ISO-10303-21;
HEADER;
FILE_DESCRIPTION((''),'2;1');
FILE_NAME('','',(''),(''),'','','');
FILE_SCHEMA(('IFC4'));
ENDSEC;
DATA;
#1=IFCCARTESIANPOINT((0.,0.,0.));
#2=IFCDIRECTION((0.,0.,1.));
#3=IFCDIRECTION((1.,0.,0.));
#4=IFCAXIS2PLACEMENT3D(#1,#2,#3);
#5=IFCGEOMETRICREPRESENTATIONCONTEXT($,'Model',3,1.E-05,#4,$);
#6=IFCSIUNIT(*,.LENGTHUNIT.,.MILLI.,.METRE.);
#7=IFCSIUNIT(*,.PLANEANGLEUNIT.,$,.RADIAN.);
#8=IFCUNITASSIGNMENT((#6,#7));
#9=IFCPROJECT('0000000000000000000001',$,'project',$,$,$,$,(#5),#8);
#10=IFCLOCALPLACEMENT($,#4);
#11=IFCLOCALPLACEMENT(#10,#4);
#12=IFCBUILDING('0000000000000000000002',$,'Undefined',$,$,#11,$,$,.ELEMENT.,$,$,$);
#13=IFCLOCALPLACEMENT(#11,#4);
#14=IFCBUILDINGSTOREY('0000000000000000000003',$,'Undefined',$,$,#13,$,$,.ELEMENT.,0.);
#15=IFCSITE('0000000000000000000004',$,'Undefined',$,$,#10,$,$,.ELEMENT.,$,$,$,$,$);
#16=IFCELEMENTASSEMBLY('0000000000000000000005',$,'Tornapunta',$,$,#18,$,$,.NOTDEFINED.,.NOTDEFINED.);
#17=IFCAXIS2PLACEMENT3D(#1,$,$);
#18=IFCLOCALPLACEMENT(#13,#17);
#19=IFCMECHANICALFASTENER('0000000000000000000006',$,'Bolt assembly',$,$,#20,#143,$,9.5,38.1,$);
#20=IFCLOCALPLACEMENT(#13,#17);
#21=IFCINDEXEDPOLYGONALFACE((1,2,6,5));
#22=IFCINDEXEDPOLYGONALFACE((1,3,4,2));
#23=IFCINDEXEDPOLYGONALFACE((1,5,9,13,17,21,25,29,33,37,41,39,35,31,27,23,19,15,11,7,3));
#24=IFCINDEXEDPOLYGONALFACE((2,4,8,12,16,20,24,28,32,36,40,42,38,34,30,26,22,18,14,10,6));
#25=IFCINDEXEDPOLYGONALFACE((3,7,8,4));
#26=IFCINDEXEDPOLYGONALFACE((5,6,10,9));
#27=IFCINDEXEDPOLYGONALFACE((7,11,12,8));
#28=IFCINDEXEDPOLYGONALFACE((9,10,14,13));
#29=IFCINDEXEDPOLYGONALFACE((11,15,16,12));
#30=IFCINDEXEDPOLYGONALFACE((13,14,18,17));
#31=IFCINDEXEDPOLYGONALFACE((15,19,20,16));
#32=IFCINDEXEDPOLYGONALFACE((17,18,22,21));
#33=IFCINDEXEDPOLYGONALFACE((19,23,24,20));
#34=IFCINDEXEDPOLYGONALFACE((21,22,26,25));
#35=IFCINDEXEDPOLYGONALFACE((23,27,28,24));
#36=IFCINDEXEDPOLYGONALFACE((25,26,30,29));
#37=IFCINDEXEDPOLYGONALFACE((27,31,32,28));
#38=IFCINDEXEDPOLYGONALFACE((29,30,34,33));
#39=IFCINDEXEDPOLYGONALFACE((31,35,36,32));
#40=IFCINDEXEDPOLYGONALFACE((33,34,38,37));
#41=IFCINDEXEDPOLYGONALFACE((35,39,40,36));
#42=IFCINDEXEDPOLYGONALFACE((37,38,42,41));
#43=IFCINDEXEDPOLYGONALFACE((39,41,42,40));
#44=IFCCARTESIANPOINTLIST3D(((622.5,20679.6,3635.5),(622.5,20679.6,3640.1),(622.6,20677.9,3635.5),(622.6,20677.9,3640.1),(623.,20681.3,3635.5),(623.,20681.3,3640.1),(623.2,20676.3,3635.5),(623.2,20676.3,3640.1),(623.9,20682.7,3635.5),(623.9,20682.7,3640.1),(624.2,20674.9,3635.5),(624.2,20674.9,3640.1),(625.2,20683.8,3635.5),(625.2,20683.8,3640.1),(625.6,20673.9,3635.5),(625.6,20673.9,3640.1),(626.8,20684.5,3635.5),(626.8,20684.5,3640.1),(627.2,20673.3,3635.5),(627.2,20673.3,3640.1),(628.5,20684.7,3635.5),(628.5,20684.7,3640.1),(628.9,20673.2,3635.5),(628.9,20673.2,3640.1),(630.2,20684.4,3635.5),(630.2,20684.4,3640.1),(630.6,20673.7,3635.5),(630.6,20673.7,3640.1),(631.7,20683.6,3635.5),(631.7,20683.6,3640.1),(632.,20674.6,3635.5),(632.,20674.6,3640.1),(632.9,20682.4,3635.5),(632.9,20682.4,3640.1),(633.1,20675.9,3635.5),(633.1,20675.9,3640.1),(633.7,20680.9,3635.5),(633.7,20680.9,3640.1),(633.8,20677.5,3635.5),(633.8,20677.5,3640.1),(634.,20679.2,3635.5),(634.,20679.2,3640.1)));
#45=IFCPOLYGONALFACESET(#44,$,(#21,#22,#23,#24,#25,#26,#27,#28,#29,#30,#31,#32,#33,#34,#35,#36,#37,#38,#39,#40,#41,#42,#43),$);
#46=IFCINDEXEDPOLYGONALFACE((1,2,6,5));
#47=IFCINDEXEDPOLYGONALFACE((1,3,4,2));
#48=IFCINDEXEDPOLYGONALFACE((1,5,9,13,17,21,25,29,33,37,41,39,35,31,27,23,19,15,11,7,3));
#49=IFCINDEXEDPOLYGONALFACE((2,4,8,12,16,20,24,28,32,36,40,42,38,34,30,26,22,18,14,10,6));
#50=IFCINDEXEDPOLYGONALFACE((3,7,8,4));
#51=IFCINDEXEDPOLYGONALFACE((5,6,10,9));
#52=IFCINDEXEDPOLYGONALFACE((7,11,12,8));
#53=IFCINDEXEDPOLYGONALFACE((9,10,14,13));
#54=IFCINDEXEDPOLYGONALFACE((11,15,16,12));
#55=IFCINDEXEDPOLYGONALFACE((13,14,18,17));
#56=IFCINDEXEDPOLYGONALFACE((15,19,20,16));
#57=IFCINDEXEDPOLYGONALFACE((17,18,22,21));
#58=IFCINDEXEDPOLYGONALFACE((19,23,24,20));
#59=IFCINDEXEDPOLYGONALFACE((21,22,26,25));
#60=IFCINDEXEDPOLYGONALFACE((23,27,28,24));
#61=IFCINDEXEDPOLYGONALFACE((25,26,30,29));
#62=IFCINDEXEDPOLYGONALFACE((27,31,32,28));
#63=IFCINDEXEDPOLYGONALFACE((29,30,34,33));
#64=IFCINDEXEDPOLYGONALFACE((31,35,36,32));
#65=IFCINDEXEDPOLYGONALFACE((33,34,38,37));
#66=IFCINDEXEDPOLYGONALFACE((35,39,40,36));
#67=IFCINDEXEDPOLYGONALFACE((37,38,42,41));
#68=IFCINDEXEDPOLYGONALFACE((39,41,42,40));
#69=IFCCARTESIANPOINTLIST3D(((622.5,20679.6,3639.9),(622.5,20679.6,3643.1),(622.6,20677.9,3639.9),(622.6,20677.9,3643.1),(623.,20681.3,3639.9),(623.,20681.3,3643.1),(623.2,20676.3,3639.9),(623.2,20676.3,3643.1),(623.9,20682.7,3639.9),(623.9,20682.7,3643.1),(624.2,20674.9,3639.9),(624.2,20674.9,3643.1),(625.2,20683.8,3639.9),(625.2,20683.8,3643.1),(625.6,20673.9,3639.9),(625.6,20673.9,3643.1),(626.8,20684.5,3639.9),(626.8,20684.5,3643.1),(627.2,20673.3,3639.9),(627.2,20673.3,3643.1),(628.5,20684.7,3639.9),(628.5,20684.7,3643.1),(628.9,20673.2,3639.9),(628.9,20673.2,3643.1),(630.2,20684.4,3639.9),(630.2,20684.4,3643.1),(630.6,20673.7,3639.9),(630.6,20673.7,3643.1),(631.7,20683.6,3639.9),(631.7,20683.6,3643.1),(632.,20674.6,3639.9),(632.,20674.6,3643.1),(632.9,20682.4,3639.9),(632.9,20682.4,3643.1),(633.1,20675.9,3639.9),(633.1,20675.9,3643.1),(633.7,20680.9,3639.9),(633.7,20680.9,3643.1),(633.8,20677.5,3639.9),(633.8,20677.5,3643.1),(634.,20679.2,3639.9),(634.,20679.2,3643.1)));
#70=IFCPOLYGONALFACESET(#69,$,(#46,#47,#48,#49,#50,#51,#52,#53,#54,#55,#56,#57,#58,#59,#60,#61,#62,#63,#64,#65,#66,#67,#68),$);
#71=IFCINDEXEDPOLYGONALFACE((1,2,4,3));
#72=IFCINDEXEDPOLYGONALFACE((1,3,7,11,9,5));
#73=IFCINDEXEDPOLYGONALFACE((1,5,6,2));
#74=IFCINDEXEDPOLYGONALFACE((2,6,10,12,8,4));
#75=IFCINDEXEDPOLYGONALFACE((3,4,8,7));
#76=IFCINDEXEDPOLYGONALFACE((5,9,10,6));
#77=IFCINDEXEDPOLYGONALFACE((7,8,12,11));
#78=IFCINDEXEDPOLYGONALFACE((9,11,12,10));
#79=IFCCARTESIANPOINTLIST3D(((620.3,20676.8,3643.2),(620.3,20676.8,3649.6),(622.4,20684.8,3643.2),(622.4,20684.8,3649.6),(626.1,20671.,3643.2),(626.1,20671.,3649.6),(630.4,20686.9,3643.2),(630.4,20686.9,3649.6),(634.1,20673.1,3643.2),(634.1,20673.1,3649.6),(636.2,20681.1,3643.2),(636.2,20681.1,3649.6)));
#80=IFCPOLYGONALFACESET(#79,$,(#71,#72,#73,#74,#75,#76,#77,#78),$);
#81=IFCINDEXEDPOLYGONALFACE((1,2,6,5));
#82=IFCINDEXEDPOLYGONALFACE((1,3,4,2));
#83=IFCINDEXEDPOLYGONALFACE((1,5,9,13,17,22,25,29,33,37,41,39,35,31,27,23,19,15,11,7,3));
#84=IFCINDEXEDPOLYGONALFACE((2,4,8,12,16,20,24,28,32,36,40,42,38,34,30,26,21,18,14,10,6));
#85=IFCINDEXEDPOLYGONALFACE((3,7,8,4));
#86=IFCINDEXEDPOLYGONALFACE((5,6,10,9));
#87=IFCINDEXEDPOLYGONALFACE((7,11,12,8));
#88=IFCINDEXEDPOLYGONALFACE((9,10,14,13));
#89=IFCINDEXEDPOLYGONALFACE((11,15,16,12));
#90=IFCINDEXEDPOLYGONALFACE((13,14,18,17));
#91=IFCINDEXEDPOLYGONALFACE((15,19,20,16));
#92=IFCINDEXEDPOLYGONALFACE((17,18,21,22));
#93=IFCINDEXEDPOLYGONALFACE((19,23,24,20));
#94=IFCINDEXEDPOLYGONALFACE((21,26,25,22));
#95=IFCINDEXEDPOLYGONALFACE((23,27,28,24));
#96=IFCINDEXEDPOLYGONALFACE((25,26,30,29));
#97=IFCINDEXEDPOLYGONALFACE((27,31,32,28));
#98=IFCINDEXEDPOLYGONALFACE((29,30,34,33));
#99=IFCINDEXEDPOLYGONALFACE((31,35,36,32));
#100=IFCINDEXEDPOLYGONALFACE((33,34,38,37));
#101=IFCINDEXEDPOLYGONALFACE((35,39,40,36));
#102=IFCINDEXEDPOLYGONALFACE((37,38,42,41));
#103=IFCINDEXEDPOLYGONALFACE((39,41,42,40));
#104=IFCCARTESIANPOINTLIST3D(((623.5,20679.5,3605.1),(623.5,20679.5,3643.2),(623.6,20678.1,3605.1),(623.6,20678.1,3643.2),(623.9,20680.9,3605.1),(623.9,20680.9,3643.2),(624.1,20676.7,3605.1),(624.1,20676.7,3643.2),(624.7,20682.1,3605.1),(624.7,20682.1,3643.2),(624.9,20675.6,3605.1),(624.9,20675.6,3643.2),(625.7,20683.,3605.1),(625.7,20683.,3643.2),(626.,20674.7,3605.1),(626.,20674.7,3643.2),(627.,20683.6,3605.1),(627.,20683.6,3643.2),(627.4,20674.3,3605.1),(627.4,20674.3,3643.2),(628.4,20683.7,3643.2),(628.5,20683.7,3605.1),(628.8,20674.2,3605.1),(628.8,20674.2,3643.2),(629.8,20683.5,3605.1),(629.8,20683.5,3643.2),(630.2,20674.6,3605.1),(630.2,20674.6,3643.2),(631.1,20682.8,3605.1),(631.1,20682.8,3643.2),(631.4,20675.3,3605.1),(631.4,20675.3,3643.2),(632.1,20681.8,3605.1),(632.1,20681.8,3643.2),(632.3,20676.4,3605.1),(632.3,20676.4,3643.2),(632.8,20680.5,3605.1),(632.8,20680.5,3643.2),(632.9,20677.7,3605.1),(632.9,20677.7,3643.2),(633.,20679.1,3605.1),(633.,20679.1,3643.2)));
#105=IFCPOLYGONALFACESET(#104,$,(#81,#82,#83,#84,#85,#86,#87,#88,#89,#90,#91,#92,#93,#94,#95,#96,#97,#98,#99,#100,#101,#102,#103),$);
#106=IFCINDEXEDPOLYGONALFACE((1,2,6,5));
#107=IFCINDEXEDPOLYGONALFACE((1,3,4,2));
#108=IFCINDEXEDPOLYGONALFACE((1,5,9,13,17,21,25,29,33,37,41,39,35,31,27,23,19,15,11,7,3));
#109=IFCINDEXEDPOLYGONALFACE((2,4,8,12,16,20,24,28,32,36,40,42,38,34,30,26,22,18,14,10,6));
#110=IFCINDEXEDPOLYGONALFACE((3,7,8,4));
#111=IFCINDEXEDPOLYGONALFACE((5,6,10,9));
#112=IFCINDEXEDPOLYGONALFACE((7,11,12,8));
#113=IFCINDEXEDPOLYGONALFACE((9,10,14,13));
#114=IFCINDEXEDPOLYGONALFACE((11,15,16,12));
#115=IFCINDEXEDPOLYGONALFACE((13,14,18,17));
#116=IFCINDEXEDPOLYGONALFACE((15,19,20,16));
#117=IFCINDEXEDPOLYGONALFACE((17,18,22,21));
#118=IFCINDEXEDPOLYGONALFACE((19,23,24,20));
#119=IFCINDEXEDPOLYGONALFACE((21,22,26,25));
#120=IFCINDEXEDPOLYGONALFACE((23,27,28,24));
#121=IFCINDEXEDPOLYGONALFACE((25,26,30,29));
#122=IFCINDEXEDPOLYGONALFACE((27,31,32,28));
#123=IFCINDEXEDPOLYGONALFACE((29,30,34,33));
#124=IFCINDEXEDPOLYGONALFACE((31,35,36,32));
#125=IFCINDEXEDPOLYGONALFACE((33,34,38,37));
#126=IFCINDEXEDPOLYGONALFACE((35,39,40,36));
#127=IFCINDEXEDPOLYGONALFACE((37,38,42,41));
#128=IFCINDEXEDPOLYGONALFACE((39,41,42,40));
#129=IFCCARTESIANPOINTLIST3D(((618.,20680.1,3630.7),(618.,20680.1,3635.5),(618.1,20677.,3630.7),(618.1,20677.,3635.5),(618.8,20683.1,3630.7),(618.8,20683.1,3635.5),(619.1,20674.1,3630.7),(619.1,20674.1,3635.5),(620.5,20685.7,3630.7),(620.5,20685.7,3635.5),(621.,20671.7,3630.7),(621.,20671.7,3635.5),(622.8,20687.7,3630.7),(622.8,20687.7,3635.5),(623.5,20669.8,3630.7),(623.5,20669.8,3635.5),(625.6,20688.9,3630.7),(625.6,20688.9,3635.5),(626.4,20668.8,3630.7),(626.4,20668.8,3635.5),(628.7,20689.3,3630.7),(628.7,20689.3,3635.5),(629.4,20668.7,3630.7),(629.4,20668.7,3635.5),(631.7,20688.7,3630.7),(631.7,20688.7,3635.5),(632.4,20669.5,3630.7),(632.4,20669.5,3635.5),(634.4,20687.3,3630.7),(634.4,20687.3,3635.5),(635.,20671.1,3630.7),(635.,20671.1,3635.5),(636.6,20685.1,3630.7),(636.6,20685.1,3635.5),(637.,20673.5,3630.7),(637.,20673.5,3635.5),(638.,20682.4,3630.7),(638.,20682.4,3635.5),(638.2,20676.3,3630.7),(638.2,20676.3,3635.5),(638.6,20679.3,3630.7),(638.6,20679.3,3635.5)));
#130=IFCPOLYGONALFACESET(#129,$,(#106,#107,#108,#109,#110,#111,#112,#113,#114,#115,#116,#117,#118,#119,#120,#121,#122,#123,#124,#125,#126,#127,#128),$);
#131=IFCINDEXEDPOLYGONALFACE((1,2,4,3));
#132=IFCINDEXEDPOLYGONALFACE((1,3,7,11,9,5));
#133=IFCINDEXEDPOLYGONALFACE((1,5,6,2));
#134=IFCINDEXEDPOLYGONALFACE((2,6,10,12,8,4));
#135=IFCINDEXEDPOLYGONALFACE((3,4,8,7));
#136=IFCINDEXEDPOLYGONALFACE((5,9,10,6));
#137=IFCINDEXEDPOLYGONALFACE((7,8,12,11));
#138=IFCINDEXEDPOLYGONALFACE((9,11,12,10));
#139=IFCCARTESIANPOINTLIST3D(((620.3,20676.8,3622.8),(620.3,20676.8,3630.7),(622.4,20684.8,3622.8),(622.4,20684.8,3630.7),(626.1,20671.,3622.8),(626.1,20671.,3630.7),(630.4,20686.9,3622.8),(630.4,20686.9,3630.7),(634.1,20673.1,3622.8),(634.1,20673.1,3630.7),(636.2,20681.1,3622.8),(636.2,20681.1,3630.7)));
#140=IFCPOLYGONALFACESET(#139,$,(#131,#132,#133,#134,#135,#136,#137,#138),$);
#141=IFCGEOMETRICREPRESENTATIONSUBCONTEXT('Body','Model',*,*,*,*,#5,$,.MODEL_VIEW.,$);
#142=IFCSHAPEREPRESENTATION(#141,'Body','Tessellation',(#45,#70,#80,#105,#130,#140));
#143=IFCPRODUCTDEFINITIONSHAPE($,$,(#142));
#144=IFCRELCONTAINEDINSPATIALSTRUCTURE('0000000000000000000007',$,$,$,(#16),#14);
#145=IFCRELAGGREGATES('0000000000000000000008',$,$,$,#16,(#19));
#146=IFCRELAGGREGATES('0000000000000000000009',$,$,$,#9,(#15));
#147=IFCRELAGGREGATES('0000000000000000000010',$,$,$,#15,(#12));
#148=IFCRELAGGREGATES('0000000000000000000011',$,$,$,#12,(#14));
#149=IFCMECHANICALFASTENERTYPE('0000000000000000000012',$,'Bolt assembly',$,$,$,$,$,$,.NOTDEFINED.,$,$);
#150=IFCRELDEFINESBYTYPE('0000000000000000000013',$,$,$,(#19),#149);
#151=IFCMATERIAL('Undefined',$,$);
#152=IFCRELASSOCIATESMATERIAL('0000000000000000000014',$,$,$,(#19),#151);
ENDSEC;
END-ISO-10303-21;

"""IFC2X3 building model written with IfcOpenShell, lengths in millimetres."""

from ifc_helpers import new_model, si_unit, frame, origin_with_axes, origin_2d_with_axis, place, context, subcontext, project, spatial, polyline, circle, outline, extrude, source, transform, mapped, material, type_object, element, aggregate, save


model = new_model("IFC2X3")

# Units and contexts
model_context = context("Model", 3, precision=1e-05, world=origin_with_axes())
body_context = subcontext(model_context, "Body", "Model", "MODEL_VIEW")
ifc_project = project(units=[si_unit("LENGTHUNIT", "METRE", prefix="MILLI"), si_unit("PLANEANGLEUNIT", "RADIAN")], contexts=[model_context])

# Site, building, storey
site_placement = place(None, origin_with_axes())
site = spatial("IfcSite", under=ifc_project, at=site_placement, Name="Undefined", CompositionType="ELEMENT")
building_placement = place(site_placement, origin_with_axes())
building = spatial("IfcBuilding", under=site, at=building_placement, Name="Undefined", CompositionType="ELEMENT")
storey_placement = place(building_placement, origin_with_axes())
storey = spatial("IfcBuildingStorey", under=building, at=storey_placement, Name="Undefined", CompositionType="ELEMENT", Elevation=0.0)

# Element assembly
assembly_1_placement = place(storey_placement, origin_with_axes())
assembly_1 = element("IfcElementAssembly", 1, at=assembly_1_placement, inside=storey, Name="Tornapunta", AssemblyPlace="NOTDEFINED", PredefinedType="NOTDEFINED")

# Mechanical fastener
ifc_material_1 = material(Name="Undefined")
mechanical_fastener_type = type_object("IfcMechanicalFastenerType", Name="Bolt assembly")
shared_shape_1 = source(origin_with_axes(), body_context, "Body", "SweptSolid", [
    extrude(circle(Radius=5.8, at=origin_2d_with_axis()), frame((0.0, -0.1, 0.0), z_axis=(0.0, 1.0, 0.0), x_axis=(1.0, 0.0, 0.0)), (0.0, 0.0, 1.0), 4.6),
    extrude(circle(Radius=5.8, at=origin_2d_with_axis()), frame((0.0, -3.1, 0.0), z_axis=(0.0, 1.0, 0.0), x_axis=(1.0, 0.0, 0.0)), (0.0, 0.0, 1.0), 3.2),
    extrude(outline(polyline([(7.1, -4.1), (7.1, 4.1), (0.0, 8.2), (-7.1, 4.1), (-7.1, -4.1), (0.0, -8.2), (7.1, -4.1)])), frame((0.0, -9.5, 0.0), z_axis=(0.0, 1.0, 0.0), x_axis=(1.0, 0.0, 0.0)), (0.0, 0.0, 1.0), 6.3),
    extrude(circle(Radius=4.8, at=origin_2d_with_axis()), frame((0.0, -3.2, 0.0), z_axis=(0.0, 1.0, 0.0), x_axis=(1.0, 0.0, 0.0)), (0.0, 0.0, 1.0), 38.1),
    extrude(circle(Radius=10.3, at=origin_2d_with_axis()), frame((0.0, 4.5, 0.0), z_axis=(0.0, 1.0, 0.0), x_axis=(1.0, 0.0, 0.0)), (0.0, 0.0, 1.0), 4.8),
    extrude(outline(polyline([(7.1, -4.1), (7.1, 4.1), (0.0, 8.2), (-7.1, 4.1), (-7.1, -4.1), (0.0, -8.2), (7.1, -4.1)])), frame((0.0, 9.3, 0.0), z_axis=(0.0, 1.0, 0.0), x_axis=(1.0, 0.0, 0.0)), (0.0, 0.0, 1.0), 7.9),
])
mechanical_fastener_1_placement = place(assembly_1_placement, frame((628.3, 20679.0, 3640.0), z_axis=(0.707107, -0.707107, 0.000016), x_axis=(-0.707107, -0.707107, -0.000016)))
mechanical_fastener_1 = element("IfcMechanicalFastener", 2, at=mechanical_fastener_1_placement, type_object=mechanical_fastener_type, material=ifc_material_1, Name="Bolt assembly", NominalDiameter=9.5, NominalLength=38.1, context=body_context, shape_type="MappedRepresentation", body=[
    mapped(shared_shape_1, transform((0.0, 0.0, 0.0))),
])
aggregate(assembly_1, [mechanical_fastener_1])

save(model, "model.ifc")
